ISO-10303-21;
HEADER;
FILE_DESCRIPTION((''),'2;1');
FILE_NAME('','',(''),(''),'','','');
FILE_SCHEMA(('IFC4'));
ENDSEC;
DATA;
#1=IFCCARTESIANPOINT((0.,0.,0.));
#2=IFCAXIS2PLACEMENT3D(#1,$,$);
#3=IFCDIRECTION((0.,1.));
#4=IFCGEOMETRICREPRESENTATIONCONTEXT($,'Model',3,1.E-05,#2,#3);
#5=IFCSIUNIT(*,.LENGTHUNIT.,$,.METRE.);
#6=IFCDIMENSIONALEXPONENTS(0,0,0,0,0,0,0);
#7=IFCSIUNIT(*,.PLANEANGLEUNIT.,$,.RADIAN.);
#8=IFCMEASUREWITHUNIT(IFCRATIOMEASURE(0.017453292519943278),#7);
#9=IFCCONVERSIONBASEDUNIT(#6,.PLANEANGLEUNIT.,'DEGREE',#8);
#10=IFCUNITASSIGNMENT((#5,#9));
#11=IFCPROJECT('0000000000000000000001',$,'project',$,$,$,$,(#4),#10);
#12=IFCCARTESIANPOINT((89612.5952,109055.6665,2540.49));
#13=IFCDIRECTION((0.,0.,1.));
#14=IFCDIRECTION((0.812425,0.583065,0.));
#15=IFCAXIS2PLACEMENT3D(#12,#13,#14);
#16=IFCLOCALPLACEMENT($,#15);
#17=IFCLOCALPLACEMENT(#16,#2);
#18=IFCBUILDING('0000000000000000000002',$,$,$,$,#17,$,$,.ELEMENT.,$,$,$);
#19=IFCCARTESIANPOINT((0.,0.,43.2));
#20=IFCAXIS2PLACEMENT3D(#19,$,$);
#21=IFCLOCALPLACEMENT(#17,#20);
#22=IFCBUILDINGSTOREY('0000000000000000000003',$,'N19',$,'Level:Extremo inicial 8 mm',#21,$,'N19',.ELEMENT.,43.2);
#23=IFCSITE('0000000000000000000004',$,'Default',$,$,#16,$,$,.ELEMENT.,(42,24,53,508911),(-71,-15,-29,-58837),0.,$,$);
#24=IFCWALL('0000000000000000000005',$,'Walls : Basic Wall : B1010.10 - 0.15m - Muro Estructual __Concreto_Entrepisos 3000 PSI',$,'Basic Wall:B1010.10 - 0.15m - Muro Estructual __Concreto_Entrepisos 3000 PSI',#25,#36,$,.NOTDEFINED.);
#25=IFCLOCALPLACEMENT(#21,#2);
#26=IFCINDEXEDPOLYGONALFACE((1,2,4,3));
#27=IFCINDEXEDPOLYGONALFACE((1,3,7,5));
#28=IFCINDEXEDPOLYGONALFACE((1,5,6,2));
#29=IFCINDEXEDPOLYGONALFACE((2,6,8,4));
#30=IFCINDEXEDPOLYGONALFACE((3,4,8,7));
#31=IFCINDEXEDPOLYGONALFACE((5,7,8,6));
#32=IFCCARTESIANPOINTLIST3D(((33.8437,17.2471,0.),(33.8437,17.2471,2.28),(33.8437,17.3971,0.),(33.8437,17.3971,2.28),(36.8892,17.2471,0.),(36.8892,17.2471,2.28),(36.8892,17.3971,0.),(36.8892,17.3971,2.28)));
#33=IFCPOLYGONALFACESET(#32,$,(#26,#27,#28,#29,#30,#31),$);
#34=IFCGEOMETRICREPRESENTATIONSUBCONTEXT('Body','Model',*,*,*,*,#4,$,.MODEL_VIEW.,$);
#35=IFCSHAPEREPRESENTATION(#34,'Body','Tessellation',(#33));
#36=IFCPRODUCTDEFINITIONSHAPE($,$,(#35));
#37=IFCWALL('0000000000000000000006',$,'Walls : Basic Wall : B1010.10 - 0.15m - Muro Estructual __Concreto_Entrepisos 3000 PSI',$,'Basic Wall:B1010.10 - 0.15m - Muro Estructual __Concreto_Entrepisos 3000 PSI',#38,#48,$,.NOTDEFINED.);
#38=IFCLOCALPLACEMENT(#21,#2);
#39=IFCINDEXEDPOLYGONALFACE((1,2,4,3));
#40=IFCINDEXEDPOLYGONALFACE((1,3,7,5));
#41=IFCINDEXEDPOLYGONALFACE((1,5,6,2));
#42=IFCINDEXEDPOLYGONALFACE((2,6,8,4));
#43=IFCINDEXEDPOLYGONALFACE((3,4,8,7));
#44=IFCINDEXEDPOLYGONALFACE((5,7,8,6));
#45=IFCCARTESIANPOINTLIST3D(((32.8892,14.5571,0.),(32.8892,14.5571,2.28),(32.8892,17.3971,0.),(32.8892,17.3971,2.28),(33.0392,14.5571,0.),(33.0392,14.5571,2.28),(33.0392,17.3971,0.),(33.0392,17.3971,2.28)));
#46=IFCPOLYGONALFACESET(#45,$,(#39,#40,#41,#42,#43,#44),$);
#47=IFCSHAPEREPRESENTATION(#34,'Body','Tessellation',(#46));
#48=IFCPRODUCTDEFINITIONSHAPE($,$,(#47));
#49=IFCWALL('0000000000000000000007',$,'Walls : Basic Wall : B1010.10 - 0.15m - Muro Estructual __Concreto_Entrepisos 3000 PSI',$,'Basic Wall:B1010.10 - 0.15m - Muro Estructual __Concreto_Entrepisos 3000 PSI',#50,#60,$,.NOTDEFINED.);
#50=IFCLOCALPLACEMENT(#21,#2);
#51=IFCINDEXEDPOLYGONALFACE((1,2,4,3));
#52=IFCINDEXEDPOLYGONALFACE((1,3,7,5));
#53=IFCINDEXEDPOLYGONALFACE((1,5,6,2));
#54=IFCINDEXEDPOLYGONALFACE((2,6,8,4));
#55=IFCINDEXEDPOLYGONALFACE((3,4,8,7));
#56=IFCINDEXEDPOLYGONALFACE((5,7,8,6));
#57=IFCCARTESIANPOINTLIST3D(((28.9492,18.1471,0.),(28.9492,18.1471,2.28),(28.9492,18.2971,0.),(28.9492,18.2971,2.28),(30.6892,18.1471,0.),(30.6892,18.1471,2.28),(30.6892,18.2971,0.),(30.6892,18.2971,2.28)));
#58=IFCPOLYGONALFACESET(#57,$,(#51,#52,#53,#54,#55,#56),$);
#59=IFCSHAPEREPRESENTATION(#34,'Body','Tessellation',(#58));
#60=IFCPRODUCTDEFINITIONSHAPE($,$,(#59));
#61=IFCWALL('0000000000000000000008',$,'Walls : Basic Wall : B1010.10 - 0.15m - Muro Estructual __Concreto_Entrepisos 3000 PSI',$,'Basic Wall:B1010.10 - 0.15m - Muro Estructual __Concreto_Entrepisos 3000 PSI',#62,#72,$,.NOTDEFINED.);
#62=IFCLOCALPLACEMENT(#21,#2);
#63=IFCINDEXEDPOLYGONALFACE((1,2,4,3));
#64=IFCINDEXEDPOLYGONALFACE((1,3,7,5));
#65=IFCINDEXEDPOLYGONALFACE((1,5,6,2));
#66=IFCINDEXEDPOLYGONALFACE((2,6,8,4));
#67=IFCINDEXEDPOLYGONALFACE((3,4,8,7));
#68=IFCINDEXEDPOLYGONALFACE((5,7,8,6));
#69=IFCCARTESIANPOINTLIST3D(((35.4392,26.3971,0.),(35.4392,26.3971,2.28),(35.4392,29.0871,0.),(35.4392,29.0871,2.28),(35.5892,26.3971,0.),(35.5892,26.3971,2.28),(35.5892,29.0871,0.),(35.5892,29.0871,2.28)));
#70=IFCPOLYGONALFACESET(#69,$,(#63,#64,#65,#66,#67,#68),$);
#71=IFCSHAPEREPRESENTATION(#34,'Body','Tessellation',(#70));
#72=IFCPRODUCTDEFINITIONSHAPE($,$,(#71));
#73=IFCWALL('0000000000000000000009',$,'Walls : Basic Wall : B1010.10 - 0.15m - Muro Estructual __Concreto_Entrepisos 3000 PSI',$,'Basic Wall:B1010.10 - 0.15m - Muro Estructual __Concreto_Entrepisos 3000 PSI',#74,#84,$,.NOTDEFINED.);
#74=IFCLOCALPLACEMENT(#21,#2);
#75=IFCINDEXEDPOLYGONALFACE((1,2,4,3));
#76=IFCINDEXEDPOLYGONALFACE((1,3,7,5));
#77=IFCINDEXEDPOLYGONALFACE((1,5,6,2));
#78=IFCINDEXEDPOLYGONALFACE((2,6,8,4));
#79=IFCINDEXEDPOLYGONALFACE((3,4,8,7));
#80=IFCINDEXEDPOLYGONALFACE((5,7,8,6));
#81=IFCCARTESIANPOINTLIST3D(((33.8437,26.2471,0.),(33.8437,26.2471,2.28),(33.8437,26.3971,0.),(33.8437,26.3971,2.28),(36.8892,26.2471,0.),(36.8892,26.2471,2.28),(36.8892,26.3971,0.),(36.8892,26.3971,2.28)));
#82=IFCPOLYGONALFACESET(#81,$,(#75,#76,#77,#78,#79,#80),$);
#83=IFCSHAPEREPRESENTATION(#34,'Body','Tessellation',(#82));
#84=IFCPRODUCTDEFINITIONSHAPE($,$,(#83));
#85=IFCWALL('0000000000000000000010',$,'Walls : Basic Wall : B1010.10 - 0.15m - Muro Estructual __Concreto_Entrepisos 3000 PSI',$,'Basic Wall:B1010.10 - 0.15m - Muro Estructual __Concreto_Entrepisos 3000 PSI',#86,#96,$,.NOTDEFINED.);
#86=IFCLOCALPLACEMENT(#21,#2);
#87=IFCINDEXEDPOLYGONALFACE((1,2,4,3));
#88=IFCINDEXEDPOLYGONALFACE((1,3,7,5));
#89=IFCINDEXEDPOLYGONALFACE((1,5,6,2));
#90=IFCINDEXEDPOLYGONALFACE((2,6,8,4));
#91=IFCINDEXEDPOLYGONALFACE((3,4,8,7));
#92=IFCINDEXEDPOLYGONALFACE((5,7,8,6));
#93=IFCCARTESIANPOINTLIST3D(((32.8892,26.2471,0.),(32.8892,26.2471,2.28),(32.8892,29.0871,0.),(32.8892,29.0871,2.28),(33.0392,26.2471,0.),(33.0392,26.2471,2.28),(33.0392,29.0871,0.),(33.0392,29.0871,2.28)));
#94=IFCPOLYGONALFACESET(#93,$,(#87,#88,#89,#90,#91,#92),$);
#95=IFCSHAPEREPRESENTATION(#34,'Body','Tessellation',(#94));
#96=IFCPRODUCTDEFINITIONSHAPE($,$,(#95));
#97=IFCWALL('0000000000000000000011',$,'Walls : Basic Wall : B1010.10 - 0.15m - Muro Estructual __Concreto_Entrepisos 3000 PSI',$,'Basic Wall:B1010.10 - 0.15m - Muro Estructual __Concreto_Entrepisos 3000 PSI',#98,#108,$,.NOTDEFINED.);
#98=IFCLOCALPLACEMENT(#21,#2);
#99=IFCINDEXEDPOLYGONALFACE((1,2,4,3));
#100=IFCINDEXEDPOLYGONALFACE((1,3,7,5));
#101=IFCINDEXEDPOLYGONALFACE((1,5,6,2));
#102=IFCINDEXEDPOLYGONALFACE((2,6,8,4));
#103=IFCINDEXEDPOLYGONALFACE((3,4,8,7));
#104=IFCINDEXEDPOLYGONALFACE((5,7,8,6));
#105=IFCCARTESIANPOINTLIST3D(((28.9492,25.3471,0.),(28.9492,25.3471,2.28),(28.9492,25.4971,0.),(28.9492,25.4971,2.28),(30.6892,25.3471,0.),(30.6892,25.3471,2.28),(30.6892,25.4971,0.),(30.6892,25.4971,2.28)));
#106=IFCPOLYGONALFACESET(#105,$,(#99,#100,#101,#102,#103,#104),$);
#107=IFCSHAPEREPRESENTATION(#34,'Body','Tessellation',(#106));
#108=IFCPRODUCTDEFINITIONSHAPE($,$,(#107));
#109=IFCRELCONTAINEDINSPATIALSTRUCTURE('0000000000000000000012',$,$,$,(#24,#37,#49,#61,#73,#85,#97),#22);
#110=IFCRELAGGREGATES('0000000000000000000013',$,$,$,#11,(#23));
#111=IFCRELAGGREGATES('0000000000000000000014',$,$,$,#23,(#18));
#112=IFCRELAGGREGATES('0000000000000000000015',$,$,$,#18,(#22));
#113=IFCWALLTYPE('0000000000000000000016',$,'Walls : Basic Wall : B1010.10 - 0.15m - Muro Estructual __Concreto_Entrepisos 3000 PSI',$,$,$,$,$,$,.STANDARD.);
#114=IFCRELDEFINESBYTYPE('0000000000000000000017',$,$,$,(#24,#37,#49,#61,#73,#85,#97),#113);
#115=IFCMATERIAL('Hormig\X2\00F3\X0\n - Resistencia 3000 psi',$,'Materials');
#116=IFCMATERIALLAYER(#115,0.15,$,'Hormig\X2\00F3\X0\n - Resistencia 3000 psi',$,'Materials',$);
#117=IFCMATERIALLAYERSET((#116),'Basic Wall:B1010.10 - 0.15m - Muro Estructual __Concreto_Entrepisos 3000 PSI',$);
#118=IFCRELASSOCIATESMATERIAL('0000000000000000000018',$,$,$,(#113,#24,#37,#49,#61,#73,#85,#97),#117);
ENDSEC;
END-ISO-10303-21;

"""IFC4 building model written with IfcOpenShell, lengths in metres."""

from ifc_helpers import new_model, entity, si_unit, converted_unit, direction, frame, frame_2d, origin, place, context, subcontext, project, spatial, rectangle, extrude, material, layer, layer_set, layer_usage, type_object, element, save


model = new_model("IFC4")

# Units and contexts
model_context = context("Model", 3, precision=1e-05, world=origin(), true_north=direction((0.0, 1.0)))
body_context = subcontext(model_context, "Body", "Model", "MODEL_VIEW")
ifc_project = project(units=[si_unit("LENGTHUNIT", "METRE"), converted_unit("PLANEANGLEUNIT", "DEGREE", entity("IfcRatioMeasure", 0.017453292519943278), si_unit("PLANEANGLEUNIT", "RADIAN"), dimensions=[0, 0, 0, 0, 0, 0, 0])], contexts=[model_context])

# Site, building, storey
site_placement = place(None, frame((89612.5952, 109055.6665, 2540.49), z_axis=(0.0, 0.0, 1.0), x_axis=(0.812425, 0.583065, 0.0)))
site = spatial("IfcSite", under=ifc_project, at=site_placement, Name="Default", CompositionType="ELEMENT", RefLatitude=(42, 24, 53, 508911), RefLongitude=(-71, -15, -29, -58837), RefElevation=0.0)
building_placement = place(site_placement, origin())
building = spatial("IfcBuilding", under=site, at=building_placement, CompositionType="ELEMENT")
storey_placement = place(building_placement, frame((0.0, 0.0, 43.2)))
storey = spatial("IfcBuildingStorey", under=building, at=storey_placement, Name="N19", ObjectType="Level:Extremo inicial 8 mm", LongName="N19", CompositionType="ELEMENT", Elevation=43.2)

# Walls
ifc_material = material(Name="Hormigón - Resistencia 3000 psi", Category="Materials")
ifc_layer_1 = layer(ifc_material, 0.15, Name="Hormigón - Resistencia 3000 psi", Category="Materials")
ifc_layer_set_1 = layer_set([ifc_layer_1], Name="Basic Wall:B1010.10 - 0.15m - Muro Estructual __Concreto_Entrepisos 3000 PSI")
wall_type_1 = type_object("IfcWallType", Name="Walls : Basic Wall : B1010.10 - 0.15m - Muro Estructual __Concreto_Entrepisos 3000 PSI", PredefinedType="STANDARD", material=ifc_layer_set_1)
ifc_layer_usage_1 = layer_usage(ifc_layer_set_1, "AXIS2", "NEGATIVE", 0.075)
wall_1_placement = place(storey_placement, frame((36.8892, 17.3221, 0.0), z_axis=(0.0, 0.0, 1.0), x_axis=(-1.0, 0.0, 0.0)))
element("IfcWall", 1, at=wall_1_placement, inside=storey, type_object=wall_type_1, material=ifc_layer_usage_1, Name="Walls : Basic Wall : B1010.10 - 0.15m - Muro Estructual __Concreto_Entrepisos 3000 PSI", ObjectType="Basic Wall:B1010.10 - 0.15m - Muro Estructual __Concreto_Entrepisos 3000 PSI", PredefinedType="NOTDEFINED", context=body_context, shape_type="SweptSolid", body=[
    extrude(rectangle(XDim=3.0455, YDim=0.15, at=frame_2d((1.5228, 0.0), x_axis=(-1.0, 0.0))), origin(), (0.0, 0.0, 1.0), 2.28),
])
ifc_layer_usage_2 = layer_usage(ifc_layer_set_1, "AXIS2", "NEGATIVE", 0.075)
wall_2_placement = place(storey_placement, frame((32.9642, 14.5571, 0.0), z_axis=(0.0, 0.0, 1.0), x_axis=(0.0, 1.0, 0.0)))
element("IfcWall", 2, at=wall_2_placement, inside=storey, type_object=wall_type_1, material=ifc_layer_usage_2, Name="Walls : Basic Wall : B1010.10 - 0.15m - Muro Estructual __Concreto_Entrepisos 3000 PSI", ObjectType="Basic Wall:B1010.10 - 0.15m - Muro Estructual __Concreto_Entrepisos 3000 PSI", PredefinedType="NOTDEFINED", context=body_context, shape_type="SweptSolid", body=[
    extrude(rectangle(XDim=2.84, YDim=0.15, at=frame_2d((1.42, 0.0), x_axis=(-1.0, 0.0))), origin(), (0.0, 0.0, 1.0), 2.28),
])
ifc_layer_usage_3 = layer_usage(ifc_layer_set_1, "AXIS2", "NEGATIVE", 0.075)
wall_3_placement = place(storey_placement, frame((30.6892, 18.2221, 0.0), z_axis=(0.0, 0.0, 1.0), x_axis=(-1.0, 0.0, 0.0)))
element("IfcWall", 3, at=wall_3_placement, inside=storey, type_object=wall_type_1, material=ifc_layer_usage_3, Name="Walls : Basic Wall : B1010.10 - 0.15m - Muro Estructual __Concreto_Entrepisos 3000 PSI", ObjectType="Basic Wall:B1010.10 - 0.15m - Muro Estructual __Concreto_Entrepisos 3000 PSI", PredefinedType="NOTDEFINED", context=body_context, shape_type="SweptSolid", body=[
    extrude(rectangle(XDim=1.74, YDim=0.15, at=frame_2d((0.87, 0.0), x_axis=(-1.0, 0.0))), origin(), (0.0, 0.0, 1.0), 2.28),
])
ifc_layer_usage_4 = layer_usage(ifc_layer_set_1, "AXIS2", "POSITIVE", -0.075)
wall_4_placement = place(storey_placement, frame((35.5142, 29.0871, 0.0), z_axis=(0.0, 0.0, 1.0), x_axis=(0.0, -1.0, 0.0)))
element("IfcWall", 4, at=wall_4_placement, inside=storey, type_object=wall_type_1, material=ifc_layer_usage_4, Name="Walls : Basic Wall : B1010.10 - 0.15m - Muro Estructual __Concreto_Entrepisos 3000 PSI", ObjectType="Basic Wall:B1010.10 - 0.15m - Muro Estructual __Concreto_Entrepisos 3000 PSI", PredefinedType="NOTDEFINED", context=body_context, shape_type="SweptSolid", body=[
    extrude(rectangle(XDim=2.69, YDim=0.15, at=frame_2d((1.345, 0.0), x_axis=(-1.0, 0.0))), origin(), (0.0, 0.0, 1.0), 2.28),
])
ifc_layer_usage_5 = layer_usage(ifc_layer_set_1, "AXIS2", "POSITIVE", -0.075)
wall_5_placement = place(storey_placement, frame((36.8892, 26.3221, 0.0), z_axis=(0.0, 0.0, 1.0), x_axis=(-1.0, 0.0, 0.0)))
element("IfcWall", 5, at=wall_5_placement, inside=storey, type_object=wall_type_1, material=ifc_layer_usage_5, Name="Walls : Basic Wall : B1010.10 - 0.15m - Muro Estructual __Concreto_Entrepisos 3000 PSI", ObjectType="Basic Wall:B1010.10 - 0.15m - Muro Estructual __Concreto_Entrepisos 3000 PSI", PredefinedType="NOTDEFINED", context=body_context, shape_type="SweptSolid", body=[
    extrude(rectangle(XDim=3.0455, YDim=0.15, at=frame_2d((1.5228, 0.0), x_axis=(-1.0, 0.0))), origin(), (0.0, 0.0, 1.0), 2.28),
])
ifc_layer_usage_6 = layer_usage(ifc_layer_set_1, "AXIS2", "POSITIVE", -0.075)
wall_6_placement = place(storey_placement, frame((32.9642, 29.0871, 0.0), z_axis=(0.0, 0.0, 1.0), x_axis=(0.0, -1.0, 0.0)))
element("IfcWall", 6, at=wall_6_placement, inside=storey, type_object=wall_type_1, material=ifc_layer_usage_6, Name="Walls : Basic Wall : B1010.10 - 0.15m - Muro Estructual __Concreto_Entrepisos 3000 PSI", ObjectType="Basic Wall:B1010.10 - 0.15m - Muro Estructual __Concreto_Entrepisos 3000 PSI", PredefinedType="NOTDEFINED", context=body_context, shape_type="SweptSolid", body=[
    extrude(rectangle(XDim=2.84, YDim=0.15, at=frame_2d((1.42, 0.0), x_axis=(-1.0, 0.0))), origin(), (0.0, 0.0, 1.0), 2.28),
])
ifc_layer_usage_7 = layer_usage(ifc_layer_set_1, "AXIS2", "POSITIVE", -0.075)
wall_7_placement = place(storey_placement, frame((30.6892, 25.4221, 0.0), z_axis=(0.0, 0.0, 1.0), x_axis=(-1.0, 0.0, 0.0)))
element("IfcWall", 7, at=wall_7_placement, inside=storey, type_object=wall_type_1, material=ifc_layer_usage_7, Name="Walls : Basic Wall : B1010.10 - 0.15m - Muro Estructual __Concreto_Entrepisos 3000 PSI", ObjectType="Basic Wall:B1010.10 - 0.15m - Muro Estructual __Concreto_Entrepisos 3000 PSI", PredefinedType="NOTDEFINED", context=body_context, shape_type="SweptSolid", body=[
    extrude(rectangle(XDim=1.74, YDim=0.15, at=frame_2d((0.87, 0.0), x_axis=(-1.0, 0.0))), origin(), (0.0, 0.0, 1.0), 2.28),
])

save(model, "model.ifc")
